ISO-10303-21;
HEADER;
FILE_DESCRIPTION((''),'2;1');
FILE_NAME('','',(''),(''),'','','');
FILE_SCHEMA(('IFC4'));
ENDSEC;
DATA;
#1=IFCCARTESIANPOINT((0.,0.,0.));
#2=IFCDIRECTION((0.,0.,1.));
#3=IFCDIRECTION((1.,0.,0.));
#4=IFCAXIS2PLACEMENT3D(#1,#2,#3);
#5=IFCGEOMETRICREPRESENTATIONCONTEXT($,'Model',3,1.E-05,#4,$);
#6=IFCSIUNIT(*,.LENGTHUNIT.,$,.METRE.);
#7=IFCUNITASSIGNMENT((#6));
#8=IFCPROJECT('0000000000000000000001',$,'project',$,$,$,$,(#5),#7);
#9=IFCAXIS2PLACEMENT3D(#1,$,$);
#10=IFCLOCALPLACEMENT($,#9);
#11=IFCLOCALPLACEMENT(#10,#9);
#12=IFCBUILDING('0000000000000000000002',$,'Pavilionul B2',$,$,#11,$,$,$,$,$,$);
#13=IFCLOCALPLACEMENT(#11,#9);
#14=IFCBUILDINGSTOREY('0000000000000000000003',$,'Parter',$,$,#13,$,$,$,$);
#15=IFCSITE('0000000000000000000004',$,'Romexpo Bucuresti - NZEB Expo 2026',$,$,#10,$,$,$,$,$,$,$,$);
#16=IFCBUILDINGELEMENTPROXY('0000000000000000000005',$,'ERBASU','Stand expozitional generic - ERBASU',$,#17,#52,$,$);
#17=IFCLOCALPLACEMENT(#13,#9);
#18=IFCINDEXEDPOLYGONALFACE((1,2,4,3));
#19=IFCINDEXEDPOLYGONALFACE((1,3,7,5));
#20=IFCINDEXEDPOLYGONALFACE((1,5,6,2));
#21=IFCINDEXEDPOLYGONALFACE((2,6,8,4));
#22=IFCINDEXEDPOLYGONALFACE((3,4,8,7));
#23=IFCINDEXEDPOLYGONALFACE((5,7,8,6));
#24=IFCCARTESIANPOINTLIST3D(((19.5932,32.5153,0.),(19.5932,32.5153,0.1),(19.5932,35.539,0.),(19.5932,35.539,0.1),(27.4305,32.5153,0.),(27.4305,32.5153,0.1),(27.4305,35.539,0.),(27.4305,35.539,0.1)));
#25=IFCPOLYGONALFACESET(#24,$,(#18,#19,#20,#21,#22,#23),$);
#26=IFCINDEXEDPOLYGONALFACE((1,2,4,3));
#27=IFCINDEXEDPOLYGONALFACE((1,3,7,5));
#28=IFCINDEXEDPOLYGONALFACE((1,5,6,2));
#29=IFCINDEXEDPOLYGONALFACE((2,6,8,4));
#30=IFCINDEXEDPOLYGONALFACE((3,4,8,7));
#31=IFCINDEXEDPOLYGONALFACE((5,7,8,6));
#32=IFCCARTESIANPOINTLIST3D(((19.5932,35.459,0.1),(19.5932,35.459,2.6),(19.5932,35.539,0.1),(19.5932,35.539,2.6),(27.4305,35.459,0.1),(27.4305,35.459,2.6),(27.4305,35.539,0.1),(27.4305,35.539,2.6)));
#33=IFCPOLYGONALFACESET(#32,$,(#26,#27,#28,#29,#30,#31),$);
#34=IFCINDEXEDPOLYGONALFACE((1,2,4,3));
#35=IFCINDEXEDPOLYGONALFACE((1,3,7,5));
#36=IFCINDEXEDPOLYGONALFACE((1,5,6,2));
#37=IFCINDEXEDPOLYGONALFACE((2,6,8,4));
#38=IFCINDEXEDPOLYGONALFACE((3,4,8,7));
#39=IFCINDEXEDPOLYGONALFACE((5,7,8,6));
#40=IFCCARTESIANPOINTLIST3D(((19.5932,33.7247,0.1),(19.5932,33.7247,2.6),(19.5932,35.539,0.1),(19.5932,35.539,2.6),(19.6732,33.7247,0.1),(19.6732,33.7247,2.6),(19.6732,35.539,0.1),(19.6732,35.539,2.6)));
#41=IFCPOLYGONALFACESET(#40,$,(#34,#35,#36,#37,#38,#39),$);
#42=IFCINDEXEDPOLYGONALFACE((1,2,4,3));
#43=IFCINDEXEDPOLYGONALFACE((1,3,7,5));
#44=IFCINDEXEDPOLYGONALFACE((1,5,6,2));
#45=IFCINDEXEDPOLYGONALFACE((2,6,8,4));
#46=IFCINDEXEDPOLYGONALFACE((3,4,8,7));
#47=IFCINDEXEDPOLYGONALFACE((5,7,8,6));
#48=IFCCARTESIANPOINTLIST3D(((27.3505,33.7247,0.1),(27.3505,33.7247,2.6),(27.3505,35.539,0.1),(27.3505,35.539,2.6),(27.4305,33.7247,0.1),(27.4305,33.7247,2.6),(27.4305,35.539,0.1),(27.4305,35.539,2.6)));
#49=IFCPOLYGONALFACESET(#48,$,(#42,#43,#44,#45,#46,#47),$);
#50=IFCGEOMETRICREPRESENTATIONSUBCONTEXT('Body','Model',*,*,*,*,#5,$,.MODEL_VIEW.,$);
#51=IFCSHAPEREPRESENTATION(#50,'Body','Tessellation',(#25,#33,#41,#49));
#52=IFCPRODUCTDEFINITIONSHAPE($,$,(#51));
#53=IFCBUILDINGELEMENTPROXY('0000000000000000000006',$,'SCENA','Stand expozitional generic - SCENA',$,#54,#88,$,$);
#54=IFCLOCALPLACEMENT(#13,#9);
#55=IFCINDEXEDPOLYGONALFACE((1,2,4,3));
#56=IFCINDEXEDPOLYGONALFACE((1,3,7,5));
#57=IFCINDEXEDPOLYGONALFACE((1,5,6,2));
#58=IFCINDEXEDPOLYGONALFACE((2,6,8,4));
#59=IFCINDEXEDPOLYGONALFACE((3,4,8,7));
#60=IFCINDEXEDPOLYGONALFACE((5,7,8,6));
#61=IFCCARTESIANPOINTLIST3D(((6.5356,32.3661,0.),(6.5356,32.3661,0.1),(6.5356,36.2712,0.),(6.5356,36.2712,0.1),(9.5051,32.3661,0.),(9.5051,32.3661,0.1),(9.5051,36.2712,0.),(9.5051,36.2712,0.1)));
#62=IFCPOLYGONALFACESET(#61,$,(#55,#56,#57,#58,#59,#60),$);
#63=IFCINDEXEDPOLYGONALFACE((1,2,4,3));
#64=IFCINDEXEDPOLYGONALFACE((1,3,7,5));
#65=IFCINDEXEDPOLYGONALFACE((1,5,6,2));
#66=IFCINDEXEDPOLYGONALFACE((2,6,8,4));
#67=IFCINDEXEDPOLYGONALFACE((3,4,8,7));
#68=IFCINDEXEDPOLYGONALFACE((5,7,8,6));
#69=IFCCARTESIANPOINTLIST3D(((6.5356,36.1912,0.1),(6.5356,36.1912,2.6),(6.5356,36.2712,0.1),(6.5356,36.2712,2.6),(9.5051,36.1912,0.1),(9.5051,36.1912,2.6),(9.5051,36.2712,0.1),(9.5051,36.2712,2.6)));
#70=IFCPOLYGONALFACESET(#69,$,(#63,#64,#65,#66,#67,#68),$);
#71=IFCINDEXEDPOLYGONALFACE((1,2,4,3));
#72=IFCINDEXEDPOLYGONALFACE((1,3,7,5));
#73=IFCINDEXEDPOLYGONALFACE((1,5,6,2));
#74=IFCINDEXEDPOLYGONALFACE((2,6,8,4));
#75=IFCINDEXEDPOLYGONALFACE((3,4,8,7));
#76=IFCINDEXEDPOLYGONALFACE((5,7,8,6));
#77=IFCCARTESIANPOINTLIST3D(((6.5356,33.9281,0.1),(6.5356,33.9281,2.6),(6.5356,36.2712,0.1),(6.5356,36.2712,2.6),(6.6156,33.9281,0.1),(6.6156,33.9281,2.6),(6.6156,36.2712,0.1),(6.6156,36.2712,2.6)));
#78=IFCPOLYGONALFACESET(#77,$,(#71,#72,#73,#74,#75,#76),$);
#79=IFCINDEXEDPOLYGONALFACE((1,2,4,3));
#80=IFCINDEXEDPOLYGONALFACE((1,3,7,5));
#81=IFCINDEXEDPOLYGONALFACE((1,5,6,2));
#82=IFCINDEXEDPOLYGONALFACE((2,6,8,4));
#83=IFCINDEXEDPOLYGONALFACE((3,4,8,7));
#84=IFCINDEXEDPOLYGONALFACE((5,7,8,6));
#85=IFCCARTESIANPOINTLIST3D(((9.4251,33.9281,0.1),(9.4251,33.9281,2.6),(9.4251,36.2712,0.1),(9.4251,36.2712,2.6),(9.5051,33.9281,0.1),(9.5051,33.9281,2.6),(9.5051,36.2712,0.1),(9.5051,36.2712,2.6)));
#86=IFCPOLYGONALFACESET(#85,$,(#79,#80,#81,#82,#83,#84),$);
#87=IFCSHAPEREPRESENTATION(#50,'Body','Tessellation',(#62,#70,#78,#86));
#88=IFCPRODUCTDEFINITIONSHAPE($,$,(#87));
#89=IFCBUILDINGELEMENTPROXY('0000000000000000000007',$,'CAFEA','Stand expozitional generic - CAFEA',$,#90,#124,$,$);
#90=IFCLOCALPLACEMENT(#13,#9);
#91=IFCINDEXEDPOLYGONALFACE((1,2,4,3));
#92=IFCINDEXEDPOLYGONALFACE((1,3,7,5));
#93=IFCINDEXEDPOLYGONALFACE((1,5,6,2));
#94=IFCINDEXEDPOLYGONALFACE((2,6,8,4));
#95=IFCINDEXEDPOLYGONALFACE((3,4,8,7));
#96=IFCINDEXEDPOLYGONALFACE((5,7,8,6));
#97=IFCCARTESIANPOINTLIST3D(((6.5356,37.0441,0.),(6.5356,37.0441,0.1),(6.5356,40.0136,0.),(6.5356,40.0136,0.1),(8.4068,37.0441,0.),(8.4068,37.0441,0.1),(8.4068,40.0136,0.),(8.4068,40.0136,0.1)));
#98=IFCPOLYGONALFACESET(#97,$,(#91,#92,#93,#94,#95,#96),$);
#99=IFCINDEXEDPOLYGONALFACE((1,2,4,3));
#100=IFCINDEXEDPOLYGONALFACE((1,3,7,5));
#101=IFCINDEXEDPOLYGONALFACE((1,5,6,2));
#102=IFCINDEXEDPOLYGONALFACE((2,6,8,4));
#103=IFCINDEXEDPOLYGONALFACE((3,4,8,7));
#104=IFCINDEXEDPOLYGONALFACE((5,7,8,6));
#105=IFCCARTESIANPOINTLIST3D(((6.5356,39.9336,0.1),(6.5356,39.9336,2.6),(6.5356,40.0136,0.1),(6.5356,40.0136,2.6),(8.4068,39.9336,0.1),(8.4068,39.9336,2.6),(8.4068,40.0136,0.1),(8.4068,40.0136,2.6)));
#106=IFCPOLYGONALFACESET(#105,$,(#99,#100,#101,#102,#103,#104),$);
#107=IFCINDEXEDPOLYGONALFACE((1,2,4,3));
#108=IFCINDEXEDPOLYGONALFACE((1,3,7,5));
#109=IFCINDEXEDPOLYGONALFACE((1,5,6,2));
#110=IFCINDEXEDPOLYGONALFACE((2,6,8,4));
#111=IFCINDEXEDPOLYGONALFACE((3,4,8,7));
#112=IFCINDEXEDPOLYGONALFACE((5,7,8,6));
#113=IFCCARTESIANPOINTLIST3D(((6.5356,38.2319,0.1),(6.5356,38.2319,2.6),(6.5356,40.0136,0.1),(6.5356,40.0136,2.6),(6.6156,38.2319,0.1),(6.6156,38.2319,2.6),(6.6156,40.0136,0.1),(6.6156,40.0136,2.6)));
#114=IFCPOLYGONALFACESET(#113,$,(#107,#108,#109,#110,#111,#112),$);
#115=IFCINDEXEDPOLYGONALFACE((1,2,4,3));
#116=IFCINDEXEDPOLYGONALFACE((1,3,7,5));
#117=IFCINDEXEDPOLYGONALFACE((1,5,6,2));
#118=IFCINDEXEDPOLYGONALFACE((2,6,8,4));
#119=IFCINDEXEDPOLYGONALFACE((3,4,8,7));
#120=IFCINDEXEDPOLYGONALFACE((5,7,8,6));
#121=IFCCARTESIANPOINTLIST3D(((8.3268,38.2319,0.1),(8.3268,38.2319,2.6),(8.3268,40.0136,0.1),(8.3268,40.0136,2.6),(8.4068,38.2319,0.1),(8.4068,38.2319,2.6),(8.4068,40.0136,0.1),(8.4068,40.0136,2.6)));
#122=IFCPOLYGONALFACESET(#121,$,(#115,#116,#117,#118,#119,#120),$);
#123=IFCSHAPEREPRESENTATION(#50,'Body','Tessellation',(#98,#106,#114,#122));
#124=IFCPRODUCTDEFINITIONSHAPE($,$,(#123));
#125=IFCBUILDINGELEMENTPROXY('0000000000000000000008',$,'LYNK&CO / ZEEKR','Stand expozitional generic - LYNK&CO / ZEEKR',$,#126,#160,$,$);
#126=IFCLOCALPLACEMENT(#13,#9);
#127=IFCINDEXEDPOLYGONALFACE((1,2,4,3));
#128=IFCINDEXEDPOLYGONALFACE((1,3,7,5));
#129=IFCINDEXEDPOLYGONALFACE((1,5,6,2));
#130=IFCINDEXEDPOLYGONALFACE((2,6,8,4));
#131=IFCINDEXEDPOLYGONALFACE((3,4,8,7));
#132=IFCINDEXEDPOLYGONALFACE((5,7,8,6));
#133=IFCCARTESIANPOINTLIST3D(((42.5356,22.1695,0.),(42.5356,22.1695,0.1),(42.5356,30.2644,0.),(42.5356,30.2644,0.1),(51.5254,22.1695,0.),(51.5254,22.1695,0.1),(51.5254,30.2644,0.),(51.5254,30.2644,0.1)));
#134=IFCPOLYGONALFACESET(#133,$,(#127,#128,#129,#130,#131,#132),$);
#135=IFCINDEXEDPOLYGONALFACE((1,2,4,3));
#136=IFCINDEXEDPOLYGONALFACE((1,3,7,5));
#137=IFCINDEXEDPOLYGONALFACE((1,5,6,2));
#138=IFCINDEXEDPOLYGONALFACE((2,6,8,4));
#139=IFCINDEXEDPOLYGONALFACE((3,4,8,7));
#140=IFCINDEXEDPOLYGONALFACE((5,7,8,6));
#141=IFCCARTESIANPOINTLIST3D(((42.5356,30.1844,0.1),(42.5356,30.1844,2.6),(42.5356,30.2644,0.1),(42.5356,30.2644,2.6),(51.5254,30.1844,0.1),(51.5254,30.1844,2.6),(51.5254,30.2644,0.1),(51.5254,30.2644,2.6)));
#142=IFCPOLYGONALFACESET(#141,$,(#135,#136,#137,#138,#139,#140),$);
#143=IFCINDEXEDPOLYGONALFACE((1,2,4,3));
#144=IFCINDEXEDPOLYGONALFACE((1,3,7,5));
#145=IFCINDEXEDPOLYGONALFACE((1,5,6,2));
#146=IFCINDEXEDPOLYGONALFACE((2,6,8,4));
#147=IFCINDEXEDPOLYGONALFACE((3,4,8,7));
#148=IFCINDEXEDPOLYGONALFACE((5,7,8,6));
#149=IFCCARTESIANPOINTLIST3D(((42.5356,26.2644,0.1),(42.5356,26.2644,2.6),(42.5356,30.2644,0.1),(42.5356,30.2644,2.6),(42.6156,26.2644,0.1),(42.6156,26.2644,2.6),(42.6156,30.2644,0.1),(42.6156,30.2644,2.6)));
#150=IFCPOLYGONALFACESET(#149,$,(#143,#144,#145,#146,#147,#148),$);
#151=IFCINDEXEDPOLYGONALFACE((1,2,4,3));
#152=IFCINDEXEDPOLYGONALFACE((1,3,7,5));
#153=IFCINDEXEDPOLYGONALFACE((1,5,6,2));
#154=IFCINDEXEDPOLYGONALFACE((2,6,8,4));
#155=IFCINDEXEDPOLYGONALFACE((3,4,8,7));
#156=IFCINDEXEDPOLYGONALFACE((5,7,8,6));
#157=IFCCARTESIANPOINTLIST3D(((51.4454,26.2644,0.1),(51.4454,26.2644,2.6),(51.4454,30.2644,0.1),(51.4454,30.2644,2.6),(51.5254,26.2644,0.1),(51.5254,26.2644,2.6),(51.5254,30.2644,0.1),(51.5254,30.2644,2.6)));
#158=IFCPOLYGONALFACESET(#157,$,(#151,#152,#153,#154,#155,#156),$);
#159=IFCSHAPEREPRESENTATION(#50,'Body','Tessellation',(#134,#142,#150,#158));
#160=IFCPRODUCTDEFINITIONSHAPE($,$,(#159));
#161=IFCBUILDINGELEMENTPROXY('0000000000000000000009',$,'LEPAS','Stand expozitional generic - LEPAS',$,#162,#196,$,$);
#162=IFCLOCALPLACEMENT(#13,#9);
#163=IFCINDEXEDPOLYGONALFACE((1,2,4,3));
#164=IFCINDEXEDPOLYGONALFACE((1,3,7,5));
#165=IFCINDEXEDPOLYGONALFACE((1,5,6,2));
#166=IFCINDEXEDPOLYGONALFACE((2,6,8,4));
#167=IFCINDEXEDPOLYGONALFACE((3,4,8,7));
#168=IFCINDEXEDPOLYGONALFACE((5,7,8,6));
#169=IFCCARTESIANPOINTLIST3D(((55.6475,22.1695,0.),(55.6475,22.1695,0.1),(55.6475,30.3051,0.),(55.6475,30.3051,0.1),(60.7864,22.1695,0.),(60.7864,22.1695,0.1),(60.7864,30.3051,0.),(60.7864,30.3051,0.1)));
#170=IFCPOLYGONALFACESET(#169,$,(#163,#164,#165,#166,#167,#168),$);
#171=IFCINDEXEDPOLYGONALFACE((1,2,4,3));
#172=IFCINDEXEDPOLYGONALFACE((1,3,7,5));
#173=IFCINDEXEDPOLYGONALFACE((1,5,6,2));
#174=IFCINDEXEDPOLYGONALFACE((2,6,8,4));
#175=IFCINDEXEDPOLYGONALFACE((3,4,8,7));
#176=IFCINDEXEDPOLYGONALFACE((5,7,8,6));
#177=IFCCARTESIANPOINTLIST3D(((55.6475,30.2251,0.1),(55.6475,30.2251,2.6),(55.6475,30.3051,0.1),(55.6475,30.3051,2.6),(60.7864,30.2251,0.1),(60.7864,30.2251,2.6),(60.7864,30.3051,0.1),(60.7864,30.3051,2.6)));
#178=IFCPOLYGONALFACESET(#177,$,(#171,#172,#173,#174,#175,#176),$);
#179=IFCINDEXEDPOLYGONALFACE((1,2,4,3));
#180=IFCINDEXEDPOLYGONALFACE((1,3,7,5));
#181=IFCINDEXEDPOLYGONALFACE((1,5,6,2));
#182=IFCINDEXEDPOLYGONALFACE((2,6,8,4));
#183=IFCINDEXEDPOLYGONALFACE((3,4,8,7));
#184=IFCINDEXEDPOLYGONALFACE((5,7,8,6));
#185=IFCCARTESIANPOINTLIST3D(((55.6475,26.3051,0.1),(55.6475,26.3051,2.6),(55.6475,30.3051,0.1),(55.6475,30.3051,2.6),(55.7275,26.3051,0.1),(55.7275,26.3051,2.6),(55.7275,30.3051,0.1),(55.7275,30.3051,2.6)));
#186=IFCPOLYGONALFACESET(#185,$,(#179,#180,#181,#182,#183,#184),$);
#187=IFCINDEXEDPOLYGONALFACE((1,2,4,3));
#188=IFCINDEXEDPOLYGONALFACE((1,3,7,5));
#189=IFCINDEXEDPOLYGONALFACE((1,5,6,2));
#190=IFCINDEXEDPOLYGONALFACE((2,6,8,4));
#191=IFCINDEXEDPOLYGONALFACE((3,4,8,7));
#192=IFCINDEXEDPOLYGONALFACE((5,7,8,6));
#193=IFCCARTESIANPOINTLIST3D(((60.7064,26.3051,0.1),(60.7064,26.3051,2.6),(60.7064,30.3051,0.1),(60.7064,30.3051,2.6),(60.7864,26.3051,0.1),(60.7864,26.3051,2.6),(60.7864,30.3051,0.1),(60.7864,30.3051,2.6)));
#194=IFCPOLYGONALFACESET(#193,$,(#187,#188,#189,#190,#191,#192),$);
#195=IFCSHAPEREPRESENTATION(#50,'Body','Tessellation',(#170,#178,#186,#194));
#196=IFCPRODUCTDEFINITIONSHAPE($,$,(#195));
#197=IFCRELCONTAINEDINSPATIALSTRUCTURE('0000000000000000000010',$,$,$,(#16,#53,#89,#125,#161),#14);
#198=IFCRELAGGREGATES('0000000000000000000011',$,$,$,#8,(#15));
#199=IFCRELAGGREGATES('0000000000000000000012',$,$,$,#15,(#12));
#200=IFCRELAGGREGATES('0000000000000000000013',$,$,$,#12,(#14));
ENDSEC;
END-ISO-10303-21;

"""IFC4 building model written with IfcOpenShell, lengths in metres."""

from ifc_helpers import new_model, si_unit, frame, frame_2d, origin, origin_with_axes, place, context, subcontext, project, spatial, rectangle, extrude, element, save


model = new_model("IFC4")

# Units and contexts
model_context = context("Model", 3, precision=1e-05, world=origin_with_axes())
body_context = subcontext(model_context, "Body", "Model", "MODEL_VIEW")
ifc_project = project(units=[si_unit("LENGTHUNIT", "METRE")], contexts=[model_context])

# Site, building, storey
site_placement = place(None, origin())
site = spatial("IfcSite", under=ifc_project, at=site_placement, Name="Romexpo Bucuresti - NZEB Expo 2026")
building_placement = place(site_placement, origin())
building = spatial("IfcBuilding", under=site, at=building_placement, Name="Pavilionul B2")
storey_placement = place(building_placement, origin())
storey = spatial("IfcBuildingStorey", under=building, at=storey_placement, Name="Parter")

# Building element proxies
proxy_1_placement = place(storey_placement, frame((19.5932, 32.5153, 0.0), z_axis=(0.0, 0.0, 1.0), x_axis=(1.0, 0.0, 0.0)))
element("IfcBuildingElementProxy", 1, at=proxy_1_placement, inside=storey, Name="ERBASU", Description="Stand expozitional generic - ERBASU", context=body_context, shape_type="SweptSolid", body=[
    extrude(rectangle(XDim=7.8373, YDim=3.0237, at=frame_2d((3.9186, 1.5119))), origin(), (0.0, 0.0, 1.0), 0.1),
    extrude(rectangle(XDim=7.8373, YDim=0.08, at=frame_2d((3.9186, 2.9837))), frame((0.0, 0.0, 0.1)), (0.0, 0.0, 1.0), 2.5),
    extrude(rectangle(XDim=0.08, YDim=1.8142, at=frame_2d((0.04, 2.1166))), frame((0.0, 0.0, 0.1)), (0.0, 0.0, 1.0), 2.5),
    extrude(rectangle(XDim=0.08, YDim=1.8142, at=frame_2d((7.7973, 2.1166))), frame((0.0, 0.0, 0.1)), (0.0, 0.0, 1.0), 2.5),
])
proxy_2_placement = place(storey_placement, frame((6.5356, 32.3661, 0.0), z_axis=(0.0, 0.0, 1.0), x_axis=(1.0, 0.0, 0.0)))
element("IfcBuildingElementProxy", 2, at=proxy_2_placement, inside=storey, Name="SCENA", Description="Stand expozitional generic - SCENA", context=body_context, shape_type="SweptSolid", body=[
    extrude(rectangle(XDim=2.9695, YDim=3.9051, at=frame_2d((1.4847, 1.9525))), origin(), (0.0, 0.0, 1.0), 0.1),
    extrude(rectangle(XDim=2.9695, YDim=0.08, at=frame_2d((1.4847, 3.8651))), frame((0.0, 0.0, 0.1)), (0.0, 0.0, 1.0), 2.5),
    extrude(rectangle(XDim=0.08, YDim=2.3431, at=frame_2d((0.04, 2.7336))), frame((0.0, 0.0, 0.1)), (0.0, 0.0, 1.0), 2.5),
    extrude(rectangle(XDim=0.08, YDim=2.3431, at=frame_2d((2.9295, 2.7336))), frame((0.0, 0.0, 0.1)), (0.0, 0.0, 1.0), 2.5),
])
proxy_3_placement = place(storey_placement, frame((6.5356, 37.0441, 0.0), z_axis=(0.0, 0.0, 1.0), x_axis=(1.0, 0.0, 0.0)))
element("IfcBuildingElementProxy", 3, at=proxy_3_placement, inside=storey, Name="CAFEA", Description="Stand expozitional generic - CAFEA", context=body_context, shape_type="SweptSolid", body=[
    extrude(rectangle(XDim=1.8712, YDim=2.9695, at=frame_2d((0.9356, 1.4847))), origin(), (0.0, 0.0, 1.0), 0.1),
    extrude(rectangle(XDim=1.8712, YDim=0.08, at=frame_2d((0.9356, 2.9295))), frame((0.0, 0.0, 0.1)), (0.0, 0.0, 1.0), 2.5),
    extrude(rectangle(XDim=0.08, YDim=1.7817, at=frame_2d((0.04, 2.0786))), frame((0.0, 0.0, 0.1)), (0.0, 0.0, 1.0), 2.5),
    extrude(rectangle(XDim=0.08, YDim=1.7817, at=frame_2d((1.8312, 2.0786))), frame((0.0, 0.0, 0.1)), (0.0, 0.0, 1.0), 2.5),
])
proxy_4_placement = place(storey_placement, frame((42.5356, 22.1695, 0.0), z_axis=(0.0, 0.0, 1.0), x_axis=(1.0, 0.0, 0.0)))
element("IfcBuildingElementProxy", 4, at=proxy_4_placement, inside=storey, Name="LYNK&CO / ZEEKR", Description="Stand expozitional generic - LYNK&CO / ZEEKR", context=body_context, shape_type="SweptSolid", body=[
    extrude(rectangle(XDim=8.9898, YDim=8.0949, at=frame_2d((4.4949, 4.0475))), origin(), (0.0, 0.0, 1.0), 0.1),
    extrude(rectangle(XDim=8.9898, YDim=0.08, at=frame_2d((4.4949, 8.0549))), frame((0.0, 0.0, 0.1)), (0.0, 0.0, 1.0), 2.5),
    extrude(rectangle(XDim=0.08, YDim=4.0, at=frame_2d((0.04, 6.0949))), frame((0.0, 0.0, 0.1)), (0.0, 0.0, 1.0), 2.5),
    extrude(rectangle(XDim=0.08, YDim=4.0, at=frame_2d((8.9498, 6.0949))), frame((0.0, 0.0, 0.1)), (0.0, 0.0, 1.0), 2.5),
])
proxy_5_placement = place(storey_placement, frame((55.6475, 22.1695, 0.0), z_axis=(0.0, 0.0, 1.0), x_axis=(1.0, 0.0, 0.0)))
element("IfcBuildingElementProxy", 5, at=proxy_5_placement, inside=storey, Name="LEPAS", Description="Stand expozitional generic - LEPAS", context=body_context, shape_type="SweptSolid", body=[
    extrude(rectangle(XDim=5.139, YDim=8.1356, at=frame_2d((2.5695, 4.0678))), origin(), (0.0, 0.0, 1.0), 0.1),
    extrude(rectangle(XDim=5.139, YDim=0.08, at=frame_2d((2.5695, 8.0956))), frame((0.0, 0.0, 0.1)), (0.0, 0.0, 1.0), 2.5),
    extrude(rectangle(XDim=0.08, YDim=4.0, at=frame_2d((0.04, 6.1356))), frame((0.0, 0.0, 0.1)), (0.0, 0.0, 1.0), 2.5),
    extrude(rectangle(XDim=0.08, YDim=4.0, at=frame_2d((5.099, 6.1356))), frame((0.0, 0.0, 0.1)), (0.0, 0.0, 1.0), 2.5),
])

save(model, "model.ifc")
